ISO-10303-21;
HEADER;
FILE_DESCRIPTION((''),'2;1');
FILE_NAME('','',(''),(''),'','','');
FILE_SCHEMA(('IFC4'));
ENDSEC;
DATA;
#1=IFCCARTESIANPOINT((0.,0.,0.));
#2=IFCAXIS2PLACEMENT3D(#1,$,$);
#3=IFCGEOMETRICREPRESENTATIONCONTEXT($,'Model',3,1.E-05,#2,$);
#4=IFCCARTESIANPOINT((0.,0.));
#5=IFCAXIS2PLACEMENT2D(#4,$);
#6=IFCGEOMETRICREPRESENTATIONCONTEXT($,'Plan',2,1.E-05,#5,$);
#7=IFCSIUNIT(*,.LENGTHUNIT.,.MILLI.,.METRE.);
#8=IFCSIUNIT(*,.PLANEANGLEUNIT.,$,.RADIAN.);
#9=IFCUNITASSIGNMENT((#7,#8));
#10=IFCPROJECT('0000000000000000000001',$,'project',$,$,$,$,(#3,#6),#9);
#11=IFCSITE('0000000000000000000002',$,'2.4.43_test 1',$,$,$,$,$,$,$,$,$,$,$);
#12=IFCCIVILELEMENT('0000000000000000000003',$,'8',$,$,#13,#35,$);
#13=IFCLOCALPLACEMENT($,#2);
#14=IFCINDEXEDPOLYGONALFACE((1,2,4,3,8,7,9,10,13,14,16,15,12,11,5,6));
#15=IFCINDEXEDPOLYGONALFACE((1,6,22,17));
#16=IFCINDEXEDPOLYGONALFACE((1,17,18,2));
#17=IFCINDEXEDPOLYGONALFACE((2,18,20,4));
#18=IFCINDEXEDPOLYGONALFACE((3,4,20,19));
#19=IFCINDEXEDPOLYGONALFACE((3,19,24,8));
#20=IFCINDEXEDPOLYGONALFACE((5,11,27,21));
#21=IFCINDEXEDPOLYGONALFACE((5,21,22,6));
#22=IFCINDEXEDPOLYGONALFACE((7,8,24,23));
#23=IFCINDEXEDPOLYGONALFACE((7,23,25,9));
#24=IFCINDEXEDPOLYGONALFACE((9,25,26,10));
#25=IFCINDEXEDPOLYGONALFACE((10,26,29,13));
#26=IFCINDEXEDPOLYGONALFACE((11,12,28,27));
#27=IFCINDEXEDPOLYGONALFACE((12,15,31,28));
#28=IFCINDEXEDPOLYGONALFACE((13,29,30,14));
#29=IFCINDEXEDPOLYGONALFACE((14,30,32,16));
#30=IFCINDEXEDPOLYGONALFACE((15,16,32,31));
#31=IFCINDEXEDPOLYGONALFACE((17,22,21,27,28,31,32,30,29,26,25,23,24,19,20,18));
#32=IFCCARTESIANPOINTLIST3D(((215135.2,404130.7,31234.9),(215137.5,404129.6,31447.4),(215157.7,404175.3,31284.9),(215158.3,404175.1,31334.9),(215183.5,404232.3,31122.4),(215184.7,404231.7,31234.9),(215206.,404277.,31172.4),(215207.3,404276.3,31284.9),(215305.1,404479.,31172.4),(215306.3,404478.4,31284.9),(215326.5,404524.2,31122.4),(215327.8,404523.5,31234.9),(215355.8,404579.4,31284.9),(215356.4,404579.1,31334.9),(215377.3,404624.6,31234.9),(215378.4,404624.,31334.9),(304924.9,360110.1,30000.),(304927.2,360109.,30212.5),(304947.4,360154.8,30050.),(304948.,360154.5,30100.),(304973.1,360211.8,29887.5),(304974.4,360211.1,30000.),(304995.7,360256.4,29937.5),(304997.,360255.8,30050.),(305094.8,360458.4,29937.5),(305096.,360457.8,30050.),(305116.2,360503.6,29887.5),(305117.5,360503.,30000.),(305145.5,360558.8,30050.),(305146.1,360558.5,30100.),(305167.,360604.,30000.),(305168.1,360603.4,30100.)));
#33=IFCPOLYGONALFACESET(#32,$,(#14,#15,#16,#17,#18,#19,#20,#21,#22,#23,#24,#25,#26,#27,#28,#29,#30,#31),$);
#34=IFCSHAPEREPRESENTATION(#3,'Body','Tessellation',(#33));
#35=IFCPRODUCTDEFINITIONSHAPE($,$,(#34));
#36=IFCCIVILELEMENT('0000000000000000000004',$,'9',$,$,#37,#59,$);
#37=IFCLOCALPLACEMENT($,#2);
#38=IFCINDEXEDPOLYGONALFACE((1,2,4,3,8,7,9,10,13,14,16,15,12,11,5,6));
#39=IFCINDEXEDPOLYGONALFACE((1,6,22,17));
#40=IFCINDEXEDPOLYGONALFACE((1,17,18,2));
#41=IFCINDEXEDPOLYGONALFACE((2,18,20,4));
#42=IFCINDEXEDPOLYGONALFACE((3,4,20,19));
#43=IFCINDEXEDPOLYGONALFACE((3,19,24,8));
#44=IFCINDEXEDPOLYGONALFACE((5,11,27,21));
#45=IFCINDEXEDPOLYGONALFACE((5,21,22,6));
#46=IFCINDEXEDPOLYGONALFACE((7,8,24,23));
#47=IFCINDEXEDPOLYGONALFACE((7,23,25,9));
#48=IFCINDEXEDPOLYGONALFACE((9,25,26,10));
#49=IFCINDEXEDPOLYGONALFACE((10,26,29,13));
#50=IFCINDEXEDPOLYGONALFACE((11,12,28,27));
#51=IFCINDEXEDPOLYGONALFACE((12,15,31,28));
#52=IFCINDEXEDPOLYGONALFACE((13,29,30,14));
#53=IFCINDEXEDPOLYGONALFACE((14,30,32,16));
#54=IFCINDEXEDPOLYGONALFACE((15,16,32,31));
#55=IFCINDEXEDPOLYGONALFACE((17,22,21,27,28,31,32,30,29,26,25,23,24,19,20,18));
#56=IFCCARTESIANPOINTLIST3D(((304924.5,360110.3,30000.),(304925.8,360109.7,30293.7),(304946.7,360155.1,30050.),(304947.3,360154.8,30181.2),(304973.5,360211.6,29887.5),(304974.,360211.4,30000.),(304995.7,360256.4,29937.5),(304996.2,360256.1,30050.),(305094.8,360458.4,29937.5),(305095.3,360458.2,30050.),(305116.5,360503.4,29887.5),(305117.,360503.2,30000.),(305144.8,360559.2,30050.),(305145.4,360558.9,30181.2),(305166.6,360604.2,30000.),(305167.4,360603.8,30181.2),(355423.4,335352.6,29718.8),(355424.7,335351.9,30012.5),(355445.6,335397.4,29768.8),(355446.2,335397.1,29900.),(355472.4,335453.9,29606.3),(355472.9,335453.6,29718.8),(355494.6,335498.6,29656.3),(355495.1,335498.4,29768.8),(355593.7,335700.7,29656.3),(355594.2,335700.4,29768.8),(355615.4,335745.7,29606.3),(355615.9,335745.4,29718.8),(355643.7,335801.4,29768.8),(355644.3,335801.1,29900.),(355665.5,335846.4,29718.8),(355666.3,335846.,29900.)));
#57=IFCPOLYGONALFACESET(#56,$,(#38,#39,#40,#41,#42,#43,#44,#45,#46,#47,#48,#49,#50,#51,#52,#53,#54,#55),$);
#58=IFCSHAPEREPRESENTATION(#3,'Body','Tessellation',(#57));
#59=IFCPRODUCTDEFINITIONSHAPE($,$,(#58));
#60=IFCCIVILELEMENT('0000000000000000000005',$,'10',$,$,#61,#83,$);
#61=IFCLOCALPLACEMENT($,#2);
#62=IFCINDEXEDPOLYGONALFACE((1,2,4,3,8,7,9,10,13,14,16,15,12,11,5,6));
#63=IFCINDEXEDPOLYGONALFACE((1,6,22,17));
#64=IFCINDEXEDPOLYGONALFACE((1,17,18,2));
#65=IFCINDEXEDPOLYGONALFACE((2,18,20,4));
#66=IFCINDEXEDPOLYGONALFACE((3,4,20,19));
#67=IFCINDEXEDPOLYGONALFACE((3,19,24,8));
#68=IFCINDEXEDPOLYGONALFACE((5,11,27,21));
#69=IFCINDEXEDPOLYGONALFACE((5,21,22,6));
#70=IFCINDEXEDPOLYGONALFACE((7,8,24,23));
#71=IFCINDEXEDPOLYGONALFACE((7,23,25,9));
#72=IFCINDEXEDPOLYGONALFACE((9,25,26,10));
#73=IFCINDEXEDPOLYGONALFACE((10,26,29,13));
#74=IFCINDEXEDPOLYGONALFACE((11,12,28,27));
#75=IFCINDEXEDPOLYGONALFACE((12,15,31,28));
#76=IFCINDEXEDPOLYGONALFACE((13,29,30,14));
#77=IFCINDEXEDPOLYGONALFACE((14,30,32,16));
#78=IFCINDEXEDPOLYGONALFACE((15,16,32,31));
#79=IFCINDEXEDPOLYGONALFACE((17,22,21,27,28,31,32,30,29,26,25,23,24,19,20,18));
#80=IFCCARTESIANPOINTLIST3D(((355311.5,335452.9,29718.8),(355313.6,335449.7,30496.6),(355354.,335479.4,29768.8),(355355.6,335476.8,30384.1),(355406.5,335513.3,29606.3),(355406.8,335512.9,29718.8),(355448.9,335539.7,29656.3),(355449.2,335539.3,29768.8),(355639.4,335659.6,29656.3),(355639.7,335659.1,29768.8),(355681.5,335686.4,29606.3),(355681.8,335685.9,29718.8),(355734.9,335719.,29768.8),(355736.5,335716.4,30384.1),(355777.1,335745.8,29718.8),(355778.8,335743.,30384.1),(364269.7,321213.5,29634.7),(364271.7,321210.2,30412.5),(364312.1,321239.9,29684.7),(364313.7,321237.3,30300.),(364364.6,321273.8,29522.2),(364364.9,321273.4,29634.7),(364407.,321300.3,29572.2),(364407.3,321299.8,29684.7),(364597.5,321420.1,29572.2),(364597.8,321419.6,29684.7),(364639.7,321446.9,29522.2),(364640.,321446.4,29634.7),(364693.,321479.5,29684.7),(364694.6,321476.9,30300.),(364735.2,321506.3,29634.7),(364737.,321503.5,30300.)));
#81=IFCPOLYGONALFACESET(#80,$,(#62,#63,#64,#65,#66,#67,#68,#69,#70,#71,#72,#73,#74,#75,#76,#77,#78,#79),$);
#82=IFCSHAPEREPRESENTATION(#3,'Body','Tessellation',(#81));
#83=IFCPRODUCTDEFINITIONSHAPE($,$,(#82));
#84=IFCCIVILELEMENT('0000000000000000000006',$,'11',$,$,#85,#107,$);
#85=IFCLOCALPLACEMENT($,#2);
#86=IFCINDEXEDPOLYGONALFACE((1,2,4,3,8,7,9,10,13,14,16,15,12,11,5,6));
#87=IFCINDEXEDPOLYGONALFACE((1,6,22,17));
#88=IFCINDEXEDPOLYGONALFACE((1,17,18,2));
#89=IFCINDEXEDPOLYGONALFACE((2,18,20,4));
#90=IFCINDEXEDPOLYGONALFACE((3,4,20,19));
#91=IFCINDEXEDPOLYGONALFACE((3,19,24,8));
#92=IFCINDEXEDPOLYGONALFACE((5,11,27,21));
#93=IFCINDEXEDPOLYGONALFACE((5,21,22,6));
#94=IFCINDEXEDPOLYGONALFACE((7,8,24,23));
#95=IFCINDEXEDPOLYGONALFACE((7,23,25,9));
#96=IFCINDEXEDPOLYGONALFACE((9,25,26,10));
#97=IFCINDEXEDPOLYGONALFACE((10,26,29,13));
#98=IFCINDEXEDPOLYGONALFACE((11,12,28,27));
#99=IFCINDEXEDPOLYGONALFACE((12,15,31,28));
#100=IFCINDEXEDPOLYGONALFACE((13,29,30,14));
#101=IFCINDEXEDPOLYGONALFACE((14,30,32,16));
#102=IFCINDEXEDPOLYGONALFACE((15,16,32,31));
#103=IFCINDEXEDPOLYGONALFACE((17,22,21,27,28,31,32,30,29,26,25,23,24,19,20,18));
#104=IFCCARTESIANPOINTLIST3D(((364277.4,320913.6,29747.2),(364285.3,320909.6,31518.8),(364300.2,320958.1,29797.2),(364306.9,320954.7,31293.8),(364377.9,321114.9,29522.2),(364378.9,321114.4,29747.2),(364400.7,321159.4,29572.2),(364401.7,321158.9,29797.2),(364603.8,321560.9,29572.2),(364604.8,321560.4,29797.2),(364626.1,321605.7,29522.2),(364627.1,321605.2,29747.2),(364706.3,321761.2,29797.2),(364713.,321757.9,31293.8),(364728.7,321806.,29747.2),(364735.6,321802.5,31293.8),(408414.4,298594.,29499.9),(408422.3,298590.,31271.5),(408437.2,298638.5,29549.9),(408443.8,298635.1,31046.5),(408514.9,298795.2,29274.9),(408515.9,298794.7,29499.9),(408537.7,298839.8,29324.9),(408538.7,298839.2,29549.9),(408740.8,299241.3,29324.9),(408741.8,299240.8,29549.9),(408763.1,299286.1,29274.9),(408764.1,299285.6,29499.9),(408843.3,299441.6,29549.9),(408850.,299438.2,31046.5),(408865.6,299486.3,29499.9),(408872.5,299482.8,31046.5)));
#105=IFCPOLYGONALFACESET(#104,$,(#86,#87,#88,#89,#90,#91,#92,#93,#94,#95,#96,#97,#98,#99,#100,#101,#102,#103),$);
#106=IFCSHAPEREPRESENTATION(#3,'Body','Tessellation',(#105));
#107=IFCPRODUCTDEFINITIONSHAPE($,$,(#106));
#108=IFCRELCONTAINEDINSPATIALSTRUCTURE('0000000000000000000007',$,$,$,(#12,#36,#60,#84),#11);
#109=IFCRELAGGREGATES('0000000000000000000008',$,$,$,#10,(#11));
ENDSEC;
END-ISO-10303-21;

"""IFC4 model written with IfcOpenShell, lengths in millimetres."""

from ifc_helpers import new_model, si_unit, frame, origin, origin_2d, context, project, spatial, polyline, outline, extrude, element, save


model = new_model("IFC4")

# Units and contexts
model_context = context("Model", 3, precision=1e-05, world=origin())
plan_context = context("Plan", 2, precision=1e-05, world=origin_2d())
ifc_project = project(units=[si_unit("LENGTHUNIT", "METRE", prefix="MILLI"), si_unit("PLANEANGLEUNIT", "RADIAN")], contexts=[model_context, plan_context])

# Site
site = spatial("IfcSite", under=ifc_project, Name="2.4.43_test 1")

# Civil elements
element("IfcCivilElement", 1, inside=site, Name="8", context=model_context, shape_type="SweptSolid", body=[
    extrude(outline(polyline([(-225.0, 162.5), (-225.0, 112.5), (-112.5, 112.5), (-112.5, 0.0), (112.5, 0.0), (112.5, 112.5), (225.0, 112.5), (225.0, 162.5), (275.0, 162.5), (275.0, 62.5), (162.5, 62.5), (162.5, -50.0), (-162.5, -50.0), (-162.5, 62.5), (-275.0, 62.5), (-275.0, 275.0)])), frame((215255.5, 404378.0, 31172.4), z_axis=(89789.693502, -44020.574062, -1234.87376), x_axis=(0.440206, 0.897897, 0.0)), (0.0, 0.0, 1.0), 100007.6),
])
element("IfcCivilElement", 2, inside=site, Name="9", context=model_context, shape_type="SweptSolid", body=[
    extrude(outline(polyline([(-225.0, 243.7), (-225.0, 112.5), (-112.5, 112.5), (-112.5, 0.0), (112.5, 0.0), (112.5, 112.5), (225.0, 112.5), (225.0, 243.7), (275.0, 243.7), (275.0, 62.5), (162.5, 62.5), (162.5, -50.0), (-162.5, -50.0), (-162.5, 62.5), (-275.0, 62.5), (-275.0, 356.2)])), frame((305045.2, 360357.4, 29937.5), z_axis=(50498.899328, -24757.747256, -281.206547), x_axis=(0.440206, 0.897897, 0.0)), (0.0, 0.0, 1.0), 56242.0),
])
element("IfcCivilElement", 3, inside=site, Name="10", context=model_context, shape_type="SweptSolid", body=[
    extrude(outline(polyline([(-225.0, 727.8), (-225.0, 112.5), (-112.5, 112.5), (-112.5, 0.0), (112.5, 0.0), (112.5, 112.5), (225.0, 112.5), (225.0, 727.8), (275.0, 727.8), (275.0, 62.5), (162.5, 62.5), (162.5, -50.0), (-162.5, -50.0), (-162.5, 62.5), (-275.0, 62.5), (-275.0, 840.3)])), frame((355544.1, 335599.6, 29656.3), z_axis=(8958.123609, -14239.487758, -84.114652), x_axis=(0.846433, 0.532495, 0.0)), (0.0, 0.0, 1.0), 16823.1),
])
element("IfcCivilElement", 4, inside=site, Name="11", context=model_context, shape_type="SweptSolid", body=[
    extrude(outline(polyline([(-450.0, 1721.6), (-450.0, 225.0), (-225.0, 225.0), (-225.0, 0.0), (225.0, 0.0), (225.0, 225.0), (450.0, 225.0), (450.0, 1721.6), (500.0, 1721.6), (500.0, 175.0), (275.0, 175.0), (275.0, -50.0), (-275.0, -50.0), (-275.0, 175.0), (-500.0, 175.0), (-500.0, 1946.6)])), frame((364502.3, 321360.2, 29572.2), z_axis=(44136.964966, -22319.623179, -247.297253), x_axis=(0.451271, 0.892387, 0.0)), (0.0, 0.0, 1.0), 49460.1),
])

save(model, "model.ifc")
